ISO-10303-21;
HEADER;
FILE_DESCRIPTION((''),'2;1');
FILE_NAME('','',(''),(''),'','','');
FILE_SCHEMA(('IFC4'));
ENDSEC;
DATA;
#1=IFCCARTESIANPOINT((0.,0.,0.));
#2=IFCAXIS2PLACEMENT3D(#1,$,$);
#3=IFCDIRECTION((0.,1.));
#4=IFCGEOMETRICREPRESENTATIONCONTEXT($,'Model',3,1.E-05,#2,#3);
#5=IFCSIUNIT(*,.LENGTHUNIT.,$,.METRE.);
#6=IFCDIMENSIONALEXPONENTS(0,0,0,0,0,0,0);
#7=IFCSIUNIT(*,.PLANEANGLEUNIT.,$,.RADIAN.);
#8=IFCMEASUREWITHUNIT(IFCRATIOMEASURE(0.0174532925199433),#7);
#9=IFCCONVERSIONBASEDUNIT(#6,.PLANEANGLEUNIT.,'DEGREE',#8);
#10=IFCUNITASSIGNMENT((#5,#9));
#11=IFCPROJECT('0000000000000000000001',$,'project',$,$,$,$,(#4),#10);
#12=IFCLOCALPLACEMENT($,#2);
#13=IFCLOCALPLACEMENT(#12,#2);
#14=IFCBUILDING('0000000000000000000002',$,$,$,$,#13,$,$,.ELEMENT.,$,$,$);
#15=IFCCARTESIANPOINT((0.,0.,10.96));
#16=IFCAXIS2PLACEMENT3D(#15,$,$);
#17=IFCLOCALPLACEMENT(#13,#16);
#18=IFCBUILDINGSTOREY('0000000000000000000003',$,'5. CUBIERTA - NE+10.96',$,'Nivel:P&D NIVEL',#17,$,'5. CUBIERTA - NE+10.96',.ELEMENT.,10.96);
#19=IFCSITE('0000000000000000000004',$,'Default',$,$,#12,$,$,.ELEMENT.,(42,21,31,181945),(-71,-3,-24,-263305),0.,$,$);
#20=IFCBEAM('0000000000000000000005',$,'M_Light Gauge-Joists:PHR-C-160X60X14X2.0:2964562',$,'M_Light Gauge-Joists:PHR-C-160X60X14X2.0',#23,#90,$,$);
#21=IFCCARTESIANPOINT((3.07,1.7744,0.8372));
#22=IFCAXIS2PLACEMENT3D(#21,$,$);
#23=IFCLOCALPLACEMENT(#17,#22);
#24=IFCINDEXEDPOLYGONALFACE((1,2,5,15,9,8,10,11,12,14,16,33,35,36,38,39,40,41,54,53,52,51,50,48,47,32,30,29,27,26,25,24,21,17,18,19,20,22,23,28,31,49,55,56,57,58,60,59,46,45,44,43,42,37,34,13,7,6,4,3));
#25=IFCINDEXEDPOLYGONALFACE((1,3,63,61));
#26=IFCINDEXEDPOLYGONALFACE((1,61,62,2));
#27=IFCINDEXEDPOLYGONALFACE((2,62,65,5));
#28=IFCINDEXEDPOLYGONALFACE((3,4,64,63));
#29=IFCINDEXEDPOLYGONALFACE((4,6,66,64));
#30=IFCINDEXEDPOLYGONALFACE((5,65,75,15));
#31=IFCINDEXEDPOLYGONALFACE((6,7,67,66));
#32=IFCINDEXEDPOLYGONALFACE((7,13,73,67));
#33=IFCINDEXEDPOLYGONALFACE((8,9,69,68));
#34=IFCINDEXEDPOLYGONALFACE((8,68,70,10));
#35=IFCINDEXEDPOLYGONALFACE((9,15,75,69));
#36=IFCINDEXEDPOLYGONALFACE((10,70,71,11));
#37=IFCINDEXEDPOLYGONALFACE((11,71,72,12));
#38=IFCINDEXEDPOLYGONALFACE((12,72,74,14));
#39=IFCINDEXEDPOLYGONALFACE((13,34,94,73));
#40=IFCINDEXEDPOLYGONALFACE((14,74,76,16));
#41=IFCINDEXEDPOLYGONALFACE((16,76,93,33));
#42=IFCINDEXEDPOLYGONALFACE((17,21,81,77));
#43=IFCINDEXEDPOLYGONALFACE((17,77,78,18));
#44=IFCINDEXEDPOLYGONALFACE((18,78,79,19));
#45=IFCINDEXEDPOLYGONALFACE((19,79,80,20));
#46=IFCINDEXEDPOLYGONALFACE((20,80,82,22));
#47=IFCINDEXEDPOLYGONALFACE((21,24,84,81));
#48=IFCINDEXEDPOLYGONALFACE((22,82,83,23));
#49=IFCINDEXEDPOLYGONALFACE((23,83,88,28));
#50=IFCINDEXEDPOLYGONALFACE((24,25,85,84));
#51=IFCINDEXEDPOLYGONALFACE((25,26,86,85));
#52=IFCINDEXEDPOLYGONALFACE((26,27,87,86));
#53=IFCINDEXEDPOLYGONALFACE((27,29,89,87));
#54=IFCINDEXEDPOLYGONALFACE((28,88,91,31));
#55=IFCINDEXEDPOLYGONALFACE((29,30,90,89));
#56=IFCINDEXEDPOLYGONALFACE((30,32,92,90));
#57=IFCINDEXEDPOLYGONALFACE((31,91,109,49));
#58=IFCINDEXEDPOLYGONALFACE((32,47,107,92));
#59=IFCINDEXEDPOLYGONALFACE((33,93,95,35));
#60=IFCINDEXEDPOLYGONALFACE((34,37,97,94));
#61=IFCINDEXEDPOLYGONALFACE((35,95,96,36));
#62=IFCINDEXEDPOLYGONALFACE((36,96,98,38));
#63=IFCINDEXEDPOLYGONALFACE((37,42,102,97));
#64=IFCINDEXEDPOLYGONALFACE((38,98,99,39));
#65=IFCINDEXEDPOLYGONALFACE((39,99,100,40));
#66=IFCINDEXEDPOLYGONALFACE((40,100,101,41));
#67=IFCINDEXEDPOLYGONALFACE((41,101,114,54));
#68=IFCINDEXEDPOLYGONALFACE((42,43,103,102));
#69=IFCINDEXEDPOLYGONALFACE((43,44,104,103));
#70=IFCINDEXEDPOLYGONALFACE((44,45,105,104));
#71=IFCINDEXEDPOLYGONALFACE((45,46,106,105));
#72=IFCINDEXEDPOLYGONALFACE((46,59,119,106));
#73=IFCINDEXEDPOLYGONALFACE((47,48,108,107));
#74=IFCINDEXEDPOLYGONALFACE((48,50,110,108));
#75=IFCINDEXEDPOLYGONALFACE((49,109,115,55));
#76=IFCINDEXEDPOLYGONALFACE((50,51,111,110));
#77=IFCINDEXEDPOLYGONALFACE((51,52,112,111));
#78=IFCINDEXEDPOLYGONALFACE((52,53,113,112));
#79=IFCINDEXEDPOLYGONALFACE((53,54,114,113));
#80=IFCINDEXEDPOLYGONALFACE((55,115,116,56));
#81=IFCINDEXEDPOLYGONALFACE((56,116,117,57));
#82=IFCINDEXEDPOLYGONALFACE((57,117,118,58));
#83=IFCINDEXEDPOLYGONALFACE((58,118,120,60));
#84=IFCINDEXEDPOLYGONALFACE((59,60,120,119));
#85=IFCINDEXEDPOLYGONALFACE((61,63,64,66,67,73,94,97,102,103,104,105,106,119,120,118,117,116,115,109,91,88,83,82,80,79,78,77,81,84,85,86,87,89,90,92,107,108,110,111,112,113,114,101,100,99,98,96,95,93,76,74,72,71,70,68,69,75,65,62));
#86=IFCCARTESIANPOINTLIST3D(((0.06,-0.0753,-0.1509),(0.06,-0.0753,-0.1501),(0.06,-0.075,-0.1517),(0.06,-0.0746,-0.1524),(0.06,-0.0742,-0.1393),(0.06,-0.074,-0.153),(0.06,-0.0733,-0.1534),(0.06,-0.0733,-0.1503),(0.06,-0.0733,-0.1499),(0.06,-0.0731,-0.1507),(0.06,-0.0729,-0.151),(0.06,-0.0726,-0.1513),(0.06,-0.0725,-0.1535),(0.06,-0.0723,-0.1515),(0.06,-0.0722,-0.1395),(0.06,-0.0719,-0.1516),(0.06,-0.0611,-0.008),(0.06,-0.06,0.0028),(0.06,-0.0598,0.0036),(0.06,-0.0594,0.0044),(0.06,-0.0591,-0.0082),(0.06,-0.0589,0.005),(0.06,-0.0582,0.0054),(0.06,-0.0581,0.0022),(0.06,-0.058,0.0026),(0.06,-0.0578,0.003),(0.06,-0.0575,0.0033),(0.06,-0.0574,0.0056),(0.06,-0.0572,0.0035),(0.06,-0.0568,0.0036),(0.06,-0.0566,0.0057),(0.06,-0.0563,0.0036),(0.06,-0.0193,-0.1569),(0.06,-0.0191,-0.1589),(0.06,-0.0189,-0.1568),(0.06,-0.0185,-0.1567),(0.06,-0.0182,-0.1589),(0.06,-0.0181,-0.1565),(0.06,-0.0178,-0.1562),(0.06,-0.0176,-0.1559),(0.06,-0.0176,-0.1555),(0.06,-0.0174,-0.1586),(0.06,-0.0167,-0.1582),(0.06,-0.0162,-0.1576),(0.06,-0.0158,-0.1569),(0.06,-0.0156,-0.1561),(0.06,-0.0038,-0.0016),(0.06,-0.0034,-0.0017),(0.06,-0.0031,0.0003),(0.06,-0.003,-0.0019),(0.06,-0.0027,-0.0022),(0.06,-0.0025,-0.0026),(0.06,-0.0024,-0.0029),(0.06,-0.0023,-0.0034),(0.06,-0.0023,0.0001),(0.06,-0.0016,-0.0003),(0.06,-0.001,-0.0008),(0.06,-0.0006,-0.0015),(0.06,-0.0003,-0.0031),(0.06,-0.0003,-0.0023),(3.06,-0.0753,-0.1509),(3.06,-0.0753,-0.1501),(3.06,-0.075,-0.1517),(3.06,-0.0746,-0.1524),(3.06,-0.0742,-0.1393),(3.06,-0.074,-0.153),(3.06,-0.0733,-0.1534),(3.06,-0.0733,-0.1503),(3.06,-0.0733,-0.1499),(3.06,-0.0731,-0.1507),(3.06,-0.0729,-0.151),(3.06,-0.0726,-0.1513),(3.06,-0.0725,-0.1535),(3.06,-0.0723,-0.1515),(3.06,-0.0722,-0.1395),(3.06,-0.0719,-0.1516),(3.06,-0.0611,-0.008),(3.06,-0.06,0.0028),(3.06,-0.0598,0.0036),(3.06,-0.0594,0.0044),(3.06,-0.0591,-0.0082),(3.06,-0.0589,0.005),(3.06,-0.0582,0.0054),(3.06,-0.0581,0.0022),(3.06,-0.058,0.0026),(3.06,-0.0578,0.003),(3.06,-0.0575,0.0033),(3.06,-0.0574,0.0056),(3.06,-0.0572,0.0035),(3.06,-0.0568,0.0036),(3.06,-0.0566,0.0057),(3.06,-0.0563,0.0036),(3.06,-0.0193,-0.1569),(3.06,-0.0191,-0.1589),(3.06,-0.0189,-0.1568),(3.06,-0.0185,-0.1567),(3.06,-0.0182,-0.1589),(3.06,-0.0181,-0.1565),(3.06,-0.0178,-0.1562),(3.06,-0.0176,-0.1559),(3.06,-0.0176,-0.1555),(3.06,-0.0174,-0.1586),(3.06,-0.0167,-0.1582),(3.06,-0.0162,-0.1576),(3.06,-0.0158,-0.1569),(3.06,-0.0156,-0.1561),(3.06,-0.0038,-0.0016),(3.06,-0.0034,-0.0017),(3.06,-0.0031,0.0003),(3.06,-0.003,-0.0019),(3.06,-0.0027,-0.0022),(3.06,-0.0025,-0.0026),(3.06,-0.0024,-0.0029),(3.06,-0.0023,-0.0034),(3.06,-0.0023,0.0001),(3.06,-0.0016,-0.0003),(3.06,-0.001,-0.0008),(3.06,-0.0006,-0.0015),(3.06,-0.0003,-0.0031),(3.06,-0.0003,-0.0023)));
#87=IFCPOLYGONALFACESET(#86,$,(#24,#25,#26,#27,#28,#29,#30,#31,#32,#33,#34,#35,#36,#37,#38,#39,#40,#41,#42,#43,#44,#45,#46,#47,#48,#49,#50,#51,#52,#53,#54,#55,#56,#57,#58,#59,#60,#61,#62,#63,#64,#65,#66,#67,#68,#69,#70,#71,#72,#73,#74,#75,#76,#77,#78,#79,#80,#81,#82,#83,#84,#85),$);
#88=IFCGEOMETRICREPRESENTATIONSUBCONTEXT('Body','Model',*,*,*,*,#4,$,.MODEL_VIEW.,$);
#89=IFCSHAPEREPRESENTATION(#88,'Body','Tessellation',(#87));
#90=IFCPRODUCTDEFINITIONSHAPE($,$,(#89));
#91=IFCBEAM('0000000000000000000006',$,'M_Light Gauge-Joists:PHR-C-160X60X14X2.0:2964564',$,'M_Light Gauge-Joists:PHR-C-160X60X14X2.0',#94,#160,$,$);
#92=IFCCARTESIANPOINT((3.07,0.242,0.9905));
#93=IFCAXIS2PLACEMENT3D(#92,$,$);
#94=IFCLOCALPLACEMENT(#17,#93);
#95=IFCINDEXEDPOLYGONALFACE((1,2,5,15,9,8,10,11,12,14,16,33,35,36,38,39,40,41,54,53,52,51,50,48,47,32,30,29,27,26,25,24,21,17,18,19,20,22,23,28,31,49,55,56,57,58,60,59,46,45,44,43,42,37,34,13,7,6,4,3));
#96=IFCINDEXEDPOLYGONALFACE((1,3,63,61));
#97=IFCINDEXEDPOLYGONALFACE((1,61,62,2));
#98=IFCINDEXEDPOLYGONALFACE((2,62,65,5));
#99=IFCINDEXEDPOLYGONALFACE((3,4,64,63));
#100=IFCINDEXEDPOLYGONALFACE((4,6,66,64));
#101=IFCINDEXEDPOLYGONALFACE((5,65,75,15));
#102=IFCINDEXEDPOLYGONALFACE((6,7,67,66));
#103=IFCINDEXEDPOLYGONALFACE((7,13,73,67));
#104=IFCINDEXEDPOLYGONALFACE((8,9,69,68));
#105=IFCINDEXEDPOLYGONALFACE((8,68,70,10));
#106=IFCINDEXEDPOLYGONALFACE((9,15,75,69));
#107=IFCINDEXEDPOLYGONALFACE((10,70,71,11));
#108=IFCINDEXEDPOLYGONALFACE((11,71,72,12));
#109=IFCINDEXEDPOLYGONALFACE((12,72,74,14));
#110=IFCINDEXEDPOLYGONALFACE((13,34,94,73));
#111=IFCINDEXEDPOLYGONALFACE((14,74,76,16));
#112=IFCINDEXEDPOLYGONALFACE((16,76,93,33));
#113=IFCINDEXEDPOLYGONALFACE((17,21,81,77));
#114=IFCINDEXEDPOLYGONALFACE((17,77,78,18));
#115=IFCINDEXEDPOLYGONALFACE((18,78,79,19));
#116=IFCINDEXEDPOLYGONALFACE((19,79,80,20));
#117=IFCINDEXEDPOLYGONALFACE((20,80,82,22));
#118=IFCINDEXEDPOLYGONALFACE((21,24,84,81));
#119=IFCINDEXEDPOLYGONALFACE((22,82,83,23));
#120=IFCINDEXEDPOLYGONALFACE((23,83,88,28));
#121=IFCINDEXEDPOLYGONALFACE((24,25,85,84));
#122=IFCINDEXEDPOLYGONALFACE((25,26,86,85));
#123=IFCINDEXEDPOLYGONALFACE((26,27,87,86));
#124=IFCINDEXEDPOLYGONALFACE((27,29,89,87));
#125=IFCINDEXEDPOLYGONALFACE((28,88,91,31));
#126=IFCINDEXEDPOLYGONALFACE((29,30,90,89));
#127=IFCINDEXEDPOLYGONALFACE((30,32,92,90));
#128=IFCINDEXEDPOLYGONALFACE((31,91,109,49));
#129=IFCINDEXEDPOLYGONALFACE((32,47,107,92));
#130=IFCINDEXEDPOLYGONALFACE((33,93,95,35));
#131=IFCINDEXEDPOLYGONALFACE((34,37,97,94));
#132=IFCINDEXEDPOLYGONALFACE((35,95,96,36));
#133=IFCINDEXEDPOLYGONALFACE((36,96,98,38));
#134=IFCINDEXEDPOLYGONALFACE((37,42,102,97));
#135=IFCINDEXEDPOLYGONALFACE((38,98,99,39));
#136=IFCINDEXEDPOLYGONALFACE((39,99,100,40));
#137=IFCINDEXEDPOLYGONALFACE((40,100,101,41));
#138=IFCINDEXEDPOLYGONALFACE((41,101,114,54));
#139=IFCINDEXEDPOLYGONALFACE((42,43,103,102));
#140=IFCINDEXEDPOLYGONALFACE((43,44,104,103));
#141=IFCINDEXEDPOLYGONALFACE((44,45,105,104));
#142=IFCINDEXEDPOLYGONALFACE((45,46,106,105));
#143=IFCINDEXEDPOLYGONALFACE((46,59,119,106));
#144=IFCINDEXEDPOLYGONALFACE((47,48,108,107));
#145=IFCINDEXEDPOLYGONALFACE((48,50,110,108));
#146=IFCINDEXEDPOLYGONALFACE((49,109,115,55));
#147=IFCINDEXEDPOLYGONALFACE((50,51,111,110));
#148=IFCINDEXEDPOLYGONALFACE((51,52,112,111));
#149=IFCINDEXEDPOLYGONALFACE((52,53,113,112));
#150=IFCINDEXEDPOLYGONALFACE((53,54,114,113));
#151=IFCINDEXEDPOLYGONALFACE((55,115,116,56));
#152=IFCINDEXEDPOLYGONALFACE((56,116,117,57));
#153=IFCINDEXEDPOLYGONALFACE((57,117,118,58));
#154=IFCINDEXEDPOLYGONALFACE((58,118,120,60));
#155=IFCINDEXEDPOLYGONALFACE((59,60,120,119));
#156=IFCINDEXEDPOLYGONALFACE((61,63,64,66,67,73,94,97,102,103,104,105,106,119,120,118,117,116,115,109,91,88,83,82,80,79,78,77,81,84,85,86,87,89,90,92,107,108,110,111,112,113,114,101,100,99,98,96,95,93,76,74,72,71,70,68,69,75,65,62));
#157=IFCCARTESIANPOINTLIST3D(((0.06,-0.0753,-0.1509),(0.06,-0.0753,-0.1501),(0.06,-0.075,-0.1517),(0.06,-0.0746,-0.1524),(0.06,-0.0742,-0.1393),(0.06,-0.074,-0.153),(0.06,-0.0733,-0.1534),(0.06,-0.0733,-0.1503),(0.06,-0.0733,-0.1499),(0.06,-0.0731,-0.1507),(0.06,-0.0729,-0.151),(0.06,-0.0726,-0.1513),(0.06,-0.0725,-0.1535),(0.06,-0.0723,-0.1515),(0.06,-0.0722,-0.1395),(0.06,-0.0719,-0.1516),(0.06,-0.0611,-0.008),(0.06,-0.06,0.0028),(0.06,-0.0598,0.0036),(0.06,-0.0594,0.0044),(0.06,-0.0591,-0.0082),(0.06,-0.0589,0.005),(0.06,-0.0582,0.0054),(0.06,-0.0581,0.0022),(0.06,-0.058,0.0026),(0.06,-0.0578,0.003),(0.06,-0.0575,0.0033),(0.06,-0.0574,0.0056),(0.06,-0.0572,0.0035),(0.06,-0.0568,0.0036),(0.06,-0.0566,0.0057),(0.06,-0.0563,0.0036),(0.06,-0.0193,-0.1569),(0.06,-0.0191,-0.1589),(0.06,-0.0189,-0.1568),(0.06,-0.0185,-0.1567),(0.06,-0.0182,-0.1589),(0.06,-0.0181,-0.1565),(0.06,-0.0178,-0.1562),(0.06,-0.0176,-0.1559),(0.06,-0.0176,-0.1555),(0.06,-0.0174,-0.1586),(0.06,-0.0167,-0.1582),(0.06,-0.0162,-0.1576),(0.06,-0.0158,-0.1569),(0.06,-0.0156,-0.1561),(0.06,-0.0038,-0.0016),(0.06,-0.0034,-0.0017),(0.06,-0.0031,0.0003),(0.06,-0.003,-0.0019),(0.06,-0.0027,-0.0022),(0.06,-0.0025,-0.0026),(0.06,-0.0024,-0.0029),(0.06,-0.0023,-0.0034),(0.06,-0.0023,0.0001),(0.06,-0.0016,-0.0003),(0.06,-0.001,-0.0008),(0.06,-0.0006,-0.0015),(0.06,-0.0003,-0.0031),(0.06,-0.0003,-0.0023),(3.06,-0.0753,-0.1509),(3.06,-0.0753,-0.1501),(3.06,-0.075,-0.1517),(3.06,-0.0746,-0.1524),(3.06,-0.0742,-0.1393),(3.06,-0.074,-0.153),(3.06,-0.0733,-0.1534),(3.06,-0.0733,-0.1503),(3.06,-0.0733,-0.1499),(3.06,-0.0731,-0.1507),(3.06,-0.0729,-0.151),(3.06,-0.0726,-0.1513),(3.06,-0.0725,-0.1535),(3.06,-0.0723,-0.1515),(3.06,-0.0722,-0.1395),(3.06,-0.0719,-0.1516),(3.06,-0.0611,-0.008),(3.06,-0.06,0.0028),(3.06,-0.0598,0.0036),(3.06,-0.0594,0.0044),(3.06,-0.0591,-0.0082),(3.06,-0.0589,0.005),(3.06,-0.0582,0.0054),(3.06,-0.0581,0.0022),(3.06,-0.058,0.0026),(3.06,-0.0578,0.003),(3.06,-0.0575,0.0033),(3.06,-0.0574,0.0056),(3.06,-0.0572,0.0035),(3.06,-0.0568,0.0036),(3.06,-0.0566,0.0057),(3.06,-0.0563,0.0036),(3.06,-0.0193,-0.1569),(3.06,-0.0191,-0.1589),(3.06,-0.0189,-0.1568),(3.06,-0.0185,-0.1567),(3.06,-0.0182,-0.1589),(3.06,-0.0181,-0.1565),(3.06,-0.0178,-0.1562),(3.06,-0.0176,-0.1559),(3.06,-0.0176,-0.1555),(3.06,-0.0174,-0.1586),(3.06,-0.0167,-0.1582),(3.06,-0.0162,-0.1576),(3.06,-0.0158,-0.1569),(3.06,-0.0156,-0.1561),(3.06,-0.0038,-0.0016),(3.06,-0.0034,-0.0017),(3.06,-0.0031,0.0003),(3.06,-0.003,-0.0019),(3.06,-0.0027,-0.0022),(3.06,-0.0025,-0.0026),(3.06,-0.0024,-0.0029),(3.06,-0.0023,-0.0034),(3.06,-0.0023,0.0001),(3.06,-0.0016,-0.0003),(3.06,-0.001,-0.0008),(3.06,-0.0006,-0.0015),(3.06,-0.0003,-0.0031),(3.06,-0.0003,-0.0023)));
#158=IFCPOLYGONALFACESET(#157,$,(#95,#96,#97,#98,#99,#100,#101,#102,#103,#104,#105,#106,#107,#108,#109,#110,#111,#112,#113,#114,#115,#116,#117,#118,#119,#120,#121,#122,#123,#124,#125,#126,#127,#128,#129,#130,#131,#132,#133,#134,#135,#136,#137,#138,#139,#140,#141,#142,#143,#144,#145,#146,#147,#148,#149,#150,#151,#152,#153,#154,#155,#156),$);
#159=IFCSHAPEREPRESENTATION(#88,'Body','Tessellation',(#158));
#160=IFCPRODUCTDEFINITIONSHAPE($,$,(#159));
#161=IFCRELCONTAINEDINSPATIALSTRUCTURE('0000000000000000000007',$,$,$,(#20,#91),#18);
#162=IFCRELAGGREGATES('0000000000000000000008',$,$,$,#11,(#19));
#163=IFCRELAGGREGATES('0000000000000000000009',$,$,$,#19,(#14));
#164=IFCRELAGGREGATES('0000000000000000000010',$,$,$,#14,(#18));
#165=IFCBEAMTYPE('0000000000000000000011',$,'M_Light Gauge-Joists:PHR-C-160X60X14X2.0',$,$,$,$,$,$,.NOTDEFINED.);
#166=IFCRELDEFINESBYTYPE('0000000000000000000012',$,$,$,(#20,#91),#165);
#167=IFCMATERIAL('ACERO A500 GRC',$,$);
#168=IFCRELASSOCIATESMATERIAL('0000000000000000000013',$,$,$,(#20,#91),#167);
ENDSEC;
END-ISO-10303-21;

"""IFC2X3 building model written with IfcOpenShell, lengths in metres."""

from ifc_helpers import new_model, entity, si_unit, converted_unit, direction, frame, frame_2d, origin, place, context, subcontext, project, spatial, polyline, circle_curve, parameter, trimmed, segment, composite_curve, outline, extrude, material, type_object, element, save


model = new_model("IFC2X3")

# Units and contexts
model_context = context("Model", 3, precision=1e-05, world=origin(), true_north=direction((0.0, 1.0)))
body_context = subcontext(model_context, "Body", "Model", "MODEL_VIEW")
ifc_project = project(units=[si_unit("LENGTHUNIT", "METRE"), converted_unit("PLANEANGLEUNIT", "DEGREE", entity("IfcRatioMeasure", 0.0174532925199433), si_unit("PLANEANGLEUNIT", "RADIAN"), dimensions=[0, 0, 0, 0, 0, 0, 0])], contexts=[model_context])

# Site, building, storey
site_placement = place(None, origin())
site = spatial("IfcSite", under=ifc_project, at=site_placement, Name="Default", CompositionType="ELEMENT", RefLatitude=(42, 21, 31, 181945), RefLongitude=(-71, -3, -24, -263305), RefElevation=0.0)
building_placement = place(site_placement, origin())
building = spatial("IfcBuilding", under=site, at=building_placement, CompositionType="ELEMENT")
storey_placement = place(building_placement, frame((0.0, 0.0, 10.96)))
storey = spatial("IfcBuildingStorey", under=building, at=storey_placement, Name="5. CUBIERTA - NE+10.96", ObjectType="Nivel:P&D NIVEL", LongName="5. CUBIERTA - NE+10.96", CompositionType="ELEMENT", Elevation=10.96)

# Beams
ifc_material_1 = material(Name="ACERO A500 GRC")
beam_type_1 = type_object("IfcBeamType", Name="M_Light Gauge-Joists:PHR-C-160X60X14X2.0", PredefinedType="NOTDEFINED")
beam_1_placement = place(storey_placement, frame((3.07, 1.7744, 0.8372)))
element("IfcBeam", 1, at=beam_1_placement, inside=storey, type_object=beam_type_1, material=ifc_material_1, Name="M_Light Gauge-Joists:PHR-C-160X60X14X2.0:2964562", ObjectType="M_Light Gauge-Joists:PHR-C-160X60X14X2.0", context=body_context, shape_type="SweptSolid", body=[
    extrude(outline(composite_curve([segment(polyline([(-0.0768, -0.0358), (0.0768, -0.0358)]), True, "CONTINUOUS"), segment(trimmed(circle_curve(frame_2d((0.0768, -0.0326), x_axis=(0.0, -1.0)), 0.0032), [parameter(0.0)], [parameter(90.0)], True, "PARAMETER"), True, "CONTINUOUS"), segment(polyline([(0.08, -0.0326), (0.08, 0.021)]), True, "CONTINUOUS"), segment(trimmed(circle_curve(frame_2d((0.0768, 0.021), x_axis=(1.0, 0.0)), 0.0032), [parameter(0.0)], [parameter(90.0)], True, "PARAMETER"), True, "CONTINUOUS"), segment(polyline([(0.0768, 0.0242), (0.066, 0.0242)]), True, "CONTINUOUS"), segment(polyline([(0.066, 0.0242), (0.066, 0.0222)]), True, "CONTINUOUS"), segment(polyline([(0.066, 0.0222), (0.0764, 0.0222)]), True, "CONTINUOUS"), segment(trimmed(circle_curve(frame_2d((0.0764, 0.0206), x_axis=(0.0, 1.0)), 0.0016), [parameter(270.0)], [parameter(0.0)], True, "PARAMETER"), False, "CONTINUOUS"), segment(polyline([(0.078, 0.0206), (0.078, -0.0322)]), True, "CONTINUOUS"), segment(trimmed(circle_curve(frame_2d((0.0764, -0.0322), x_axis=(1.0, 0.0)), 0.0016), [parameter(270.0)], [parameter(0.0)], True, "PARAMETER"), False, "CONTINUOUS"), segment(polyline([(0.0764, -0.0338), (-0.0764, -0.0338)]), True, "CONTINUOUS"), segment(trimmed(circle_curve(frame_2d((-0.0764, -0.0322), x_axis=(0.0, -1.0)), 0.0016), [parameter(270.0)], [parameter(0.0)], True, "PARAMETER"), False, "CONTINUOUS"), segment(polyline([(-0.078, -0.0322), (-0.078, 0.0206)]), True, "CONTINUOUS"), segment(trimmed(circle_curve(frame_2d((-0.0764, 0.0206), x_axis=(-1.0, 0.0)), 0.0016), [parameter(270.0)], [parameter(0.0)], True, "PARAMETER"), False, "CONTINUOUS"), segment(polyline([(-0.0764, 0.0222), (-0.066, 0.0222)]), True, "CONTINUOUS"), segment(polyline([(-0.066, 0.0222), (-0.066, 0.0242)]), True, "CONTINUOUS"), segment(polyline([(-0.066, 0.0242), (-0.0768, 0.0242)]), True, "CONTINUOUS"), segment(trimmed(circle_curve(frame_2d((-0.0768, 0.021), x_axis=(0.0, 1.0)), 0.0032), [parameter(0.0)], [parameter(90.0)], True, "PARAMETER"), True, "CONTINUOUS"), segment(polyline([(-0.08, 0.021), (-0.08, -0.0326)]), True, "CONTINUOUS"), segment(trimmed(circle_curve(frame_2d((-0.0768, -0.0326), x_axis=(-1.0, 0.0)), 0.0032), [parameter(0.0)], [parameter(90.0)], True, "PARAMETER"), True, "CONTINUOUS")], self_intersect=False)), frame((0.06, -0.0436, -0.076), z_axis=(1.0, 0.0, 0.0), x_axis=(0.0, 0.099504, 0.995037)), (0.0, 0.0, 1.0), 3.0),
])
beam_2_placement = place(storey_placement, frame((3.07, 0.242, 0.9905)))
element("IfcBeam", 2, at=beam_2_placement, inside=storey, type_object=beam_type_1, material=ifc_material_1, Name="M_Light Gauge-Joists:PHR-C-160X60X14X2.0:2964564", ObjectType="M_Light Gauge-Joists:PHR-C-160X60X14X2.0", context=body_context, shape_type="SweptSolid", body=[
    extrude(outline(composite_curve([segment(polyline([(-0.0768, -0.0358), (0.0768, -0.0358)]), True, "CONTINUOUS"), segment(trimmed(circle_curve(frame_2d((0.0768, -0.0326), x_axis=(0.0, -1.0)), 0.0032), [parameter(0.0)], [parameter(90.0)], True, "PARAMETER"), True, "CONTINUOUS"), segment(polyline([(0.08, -0.0326), (0.08, 0.021)]), True, "CONTINUOUS"), segment(trimmed(circle_curve(frame_2d((0.0768, 0.021), x_axis=(1.0, 0.0)), 0.0032), [parameter(0.0)], [parameter(90.0)], True, "PARAMETER"), True, "CONTINUOUS"), segment(polyline([(0.0768, 0.0242), (0.066, 0.0242)]), True, "CONTINUOUS"), segment(polyline([(0.066, 0.0242), (0.066, 0.0222)]), True, "CONTINUOUS"), segment(polyline([(0.066, 0.0222), (0.0764, 0.0222)]), True, "CONTINUOUS"), segment(trimmed(circle_curve(frame_2d((0.0764, 0.0206), x_axis=(0.0, 1.0)), 0.0016), [parameter(270.0)], [parameter(0.0)], True, "PARAMETER"), False, "CONTINUOUS"), segment(polyline([(0.078, 0.0206), (0.078, -0.0322)]), True, "CONTINUOUS"), segment(trimmed(circle_curve(frame_2d((0.0764, -0.0322), x_axis=(1.0, 0.0)), 0.0016), [parameter(270.0)], [parameter(0.0)], True, "PARAMETER"), False, "CONTINUOUS"), segment(polyline([(0.0764, -0.0338), (-0.0764, -0.0338)]), True, "CONTINUOUS"), segment(trimmed(circle_curve(frame_2d((-0.0764, -0.0322), x_axis=(0.0, -1.0)), 0.0016), [parameter(270.0)], [parameter(0.0)], True, "PARAMETER"), False, "CONTINUOUS"), segment(polyline([(-0.078, -0.0322), (-0.078, 0.0206)]), True, "CONTINUOUS"), segment(trimmed(circle_curve(frame_2d((-0.0764, 0.0206), x_axis=(-1.0, 0.0)), 0.0016), [parameter(270.0)], [parameter(0.0)], True, "PARAMETER"), False, "CONTINUOUS"), segment(polyline([(-0.0764, 0.0222), (-0.066, 0.0222)]), True, "CONTINUOUS"), segment(polyline([(-0.066, 0.0222), (-0.066, 0.0242)]), True, "CONTINUOUS"), segment(polyline([(-0.066, 0.0242), (-0.0768, 0.0242)]), True, "CONTINUOUS"), segment(trimmed(circle_curve(frame_2d((-0.0768, 0.021), x_axis=(0.0, 1.0)), 0.0032), [parameter(0.0)], [parameter(90.0)], True, "PARAMETER"), True, "CONTINUOUS"), segment(polyline([(-0.08, 0.021), (-0.08, -0.0326)]), True, "CONTINUOUS"), segment(trimmed(circle_curve(frame_2d((-0.0768, -0.0326), x_axis=(-1.0, 0.0)), 0.0032), [parameter(0.0)], [parameter(90.0)], True, "PARAMETER"), True, "CONTINUOUS")], self_intersect=False)), frame((0.06, -0.0436, -0.076), z_axis=(1.0, 0.0, 0.0), x_axis=(0.0, 0.099504, 0.995037)), (0.0, 0.0, 1.0), 3.0),
])

save(model, "model.ifc")
